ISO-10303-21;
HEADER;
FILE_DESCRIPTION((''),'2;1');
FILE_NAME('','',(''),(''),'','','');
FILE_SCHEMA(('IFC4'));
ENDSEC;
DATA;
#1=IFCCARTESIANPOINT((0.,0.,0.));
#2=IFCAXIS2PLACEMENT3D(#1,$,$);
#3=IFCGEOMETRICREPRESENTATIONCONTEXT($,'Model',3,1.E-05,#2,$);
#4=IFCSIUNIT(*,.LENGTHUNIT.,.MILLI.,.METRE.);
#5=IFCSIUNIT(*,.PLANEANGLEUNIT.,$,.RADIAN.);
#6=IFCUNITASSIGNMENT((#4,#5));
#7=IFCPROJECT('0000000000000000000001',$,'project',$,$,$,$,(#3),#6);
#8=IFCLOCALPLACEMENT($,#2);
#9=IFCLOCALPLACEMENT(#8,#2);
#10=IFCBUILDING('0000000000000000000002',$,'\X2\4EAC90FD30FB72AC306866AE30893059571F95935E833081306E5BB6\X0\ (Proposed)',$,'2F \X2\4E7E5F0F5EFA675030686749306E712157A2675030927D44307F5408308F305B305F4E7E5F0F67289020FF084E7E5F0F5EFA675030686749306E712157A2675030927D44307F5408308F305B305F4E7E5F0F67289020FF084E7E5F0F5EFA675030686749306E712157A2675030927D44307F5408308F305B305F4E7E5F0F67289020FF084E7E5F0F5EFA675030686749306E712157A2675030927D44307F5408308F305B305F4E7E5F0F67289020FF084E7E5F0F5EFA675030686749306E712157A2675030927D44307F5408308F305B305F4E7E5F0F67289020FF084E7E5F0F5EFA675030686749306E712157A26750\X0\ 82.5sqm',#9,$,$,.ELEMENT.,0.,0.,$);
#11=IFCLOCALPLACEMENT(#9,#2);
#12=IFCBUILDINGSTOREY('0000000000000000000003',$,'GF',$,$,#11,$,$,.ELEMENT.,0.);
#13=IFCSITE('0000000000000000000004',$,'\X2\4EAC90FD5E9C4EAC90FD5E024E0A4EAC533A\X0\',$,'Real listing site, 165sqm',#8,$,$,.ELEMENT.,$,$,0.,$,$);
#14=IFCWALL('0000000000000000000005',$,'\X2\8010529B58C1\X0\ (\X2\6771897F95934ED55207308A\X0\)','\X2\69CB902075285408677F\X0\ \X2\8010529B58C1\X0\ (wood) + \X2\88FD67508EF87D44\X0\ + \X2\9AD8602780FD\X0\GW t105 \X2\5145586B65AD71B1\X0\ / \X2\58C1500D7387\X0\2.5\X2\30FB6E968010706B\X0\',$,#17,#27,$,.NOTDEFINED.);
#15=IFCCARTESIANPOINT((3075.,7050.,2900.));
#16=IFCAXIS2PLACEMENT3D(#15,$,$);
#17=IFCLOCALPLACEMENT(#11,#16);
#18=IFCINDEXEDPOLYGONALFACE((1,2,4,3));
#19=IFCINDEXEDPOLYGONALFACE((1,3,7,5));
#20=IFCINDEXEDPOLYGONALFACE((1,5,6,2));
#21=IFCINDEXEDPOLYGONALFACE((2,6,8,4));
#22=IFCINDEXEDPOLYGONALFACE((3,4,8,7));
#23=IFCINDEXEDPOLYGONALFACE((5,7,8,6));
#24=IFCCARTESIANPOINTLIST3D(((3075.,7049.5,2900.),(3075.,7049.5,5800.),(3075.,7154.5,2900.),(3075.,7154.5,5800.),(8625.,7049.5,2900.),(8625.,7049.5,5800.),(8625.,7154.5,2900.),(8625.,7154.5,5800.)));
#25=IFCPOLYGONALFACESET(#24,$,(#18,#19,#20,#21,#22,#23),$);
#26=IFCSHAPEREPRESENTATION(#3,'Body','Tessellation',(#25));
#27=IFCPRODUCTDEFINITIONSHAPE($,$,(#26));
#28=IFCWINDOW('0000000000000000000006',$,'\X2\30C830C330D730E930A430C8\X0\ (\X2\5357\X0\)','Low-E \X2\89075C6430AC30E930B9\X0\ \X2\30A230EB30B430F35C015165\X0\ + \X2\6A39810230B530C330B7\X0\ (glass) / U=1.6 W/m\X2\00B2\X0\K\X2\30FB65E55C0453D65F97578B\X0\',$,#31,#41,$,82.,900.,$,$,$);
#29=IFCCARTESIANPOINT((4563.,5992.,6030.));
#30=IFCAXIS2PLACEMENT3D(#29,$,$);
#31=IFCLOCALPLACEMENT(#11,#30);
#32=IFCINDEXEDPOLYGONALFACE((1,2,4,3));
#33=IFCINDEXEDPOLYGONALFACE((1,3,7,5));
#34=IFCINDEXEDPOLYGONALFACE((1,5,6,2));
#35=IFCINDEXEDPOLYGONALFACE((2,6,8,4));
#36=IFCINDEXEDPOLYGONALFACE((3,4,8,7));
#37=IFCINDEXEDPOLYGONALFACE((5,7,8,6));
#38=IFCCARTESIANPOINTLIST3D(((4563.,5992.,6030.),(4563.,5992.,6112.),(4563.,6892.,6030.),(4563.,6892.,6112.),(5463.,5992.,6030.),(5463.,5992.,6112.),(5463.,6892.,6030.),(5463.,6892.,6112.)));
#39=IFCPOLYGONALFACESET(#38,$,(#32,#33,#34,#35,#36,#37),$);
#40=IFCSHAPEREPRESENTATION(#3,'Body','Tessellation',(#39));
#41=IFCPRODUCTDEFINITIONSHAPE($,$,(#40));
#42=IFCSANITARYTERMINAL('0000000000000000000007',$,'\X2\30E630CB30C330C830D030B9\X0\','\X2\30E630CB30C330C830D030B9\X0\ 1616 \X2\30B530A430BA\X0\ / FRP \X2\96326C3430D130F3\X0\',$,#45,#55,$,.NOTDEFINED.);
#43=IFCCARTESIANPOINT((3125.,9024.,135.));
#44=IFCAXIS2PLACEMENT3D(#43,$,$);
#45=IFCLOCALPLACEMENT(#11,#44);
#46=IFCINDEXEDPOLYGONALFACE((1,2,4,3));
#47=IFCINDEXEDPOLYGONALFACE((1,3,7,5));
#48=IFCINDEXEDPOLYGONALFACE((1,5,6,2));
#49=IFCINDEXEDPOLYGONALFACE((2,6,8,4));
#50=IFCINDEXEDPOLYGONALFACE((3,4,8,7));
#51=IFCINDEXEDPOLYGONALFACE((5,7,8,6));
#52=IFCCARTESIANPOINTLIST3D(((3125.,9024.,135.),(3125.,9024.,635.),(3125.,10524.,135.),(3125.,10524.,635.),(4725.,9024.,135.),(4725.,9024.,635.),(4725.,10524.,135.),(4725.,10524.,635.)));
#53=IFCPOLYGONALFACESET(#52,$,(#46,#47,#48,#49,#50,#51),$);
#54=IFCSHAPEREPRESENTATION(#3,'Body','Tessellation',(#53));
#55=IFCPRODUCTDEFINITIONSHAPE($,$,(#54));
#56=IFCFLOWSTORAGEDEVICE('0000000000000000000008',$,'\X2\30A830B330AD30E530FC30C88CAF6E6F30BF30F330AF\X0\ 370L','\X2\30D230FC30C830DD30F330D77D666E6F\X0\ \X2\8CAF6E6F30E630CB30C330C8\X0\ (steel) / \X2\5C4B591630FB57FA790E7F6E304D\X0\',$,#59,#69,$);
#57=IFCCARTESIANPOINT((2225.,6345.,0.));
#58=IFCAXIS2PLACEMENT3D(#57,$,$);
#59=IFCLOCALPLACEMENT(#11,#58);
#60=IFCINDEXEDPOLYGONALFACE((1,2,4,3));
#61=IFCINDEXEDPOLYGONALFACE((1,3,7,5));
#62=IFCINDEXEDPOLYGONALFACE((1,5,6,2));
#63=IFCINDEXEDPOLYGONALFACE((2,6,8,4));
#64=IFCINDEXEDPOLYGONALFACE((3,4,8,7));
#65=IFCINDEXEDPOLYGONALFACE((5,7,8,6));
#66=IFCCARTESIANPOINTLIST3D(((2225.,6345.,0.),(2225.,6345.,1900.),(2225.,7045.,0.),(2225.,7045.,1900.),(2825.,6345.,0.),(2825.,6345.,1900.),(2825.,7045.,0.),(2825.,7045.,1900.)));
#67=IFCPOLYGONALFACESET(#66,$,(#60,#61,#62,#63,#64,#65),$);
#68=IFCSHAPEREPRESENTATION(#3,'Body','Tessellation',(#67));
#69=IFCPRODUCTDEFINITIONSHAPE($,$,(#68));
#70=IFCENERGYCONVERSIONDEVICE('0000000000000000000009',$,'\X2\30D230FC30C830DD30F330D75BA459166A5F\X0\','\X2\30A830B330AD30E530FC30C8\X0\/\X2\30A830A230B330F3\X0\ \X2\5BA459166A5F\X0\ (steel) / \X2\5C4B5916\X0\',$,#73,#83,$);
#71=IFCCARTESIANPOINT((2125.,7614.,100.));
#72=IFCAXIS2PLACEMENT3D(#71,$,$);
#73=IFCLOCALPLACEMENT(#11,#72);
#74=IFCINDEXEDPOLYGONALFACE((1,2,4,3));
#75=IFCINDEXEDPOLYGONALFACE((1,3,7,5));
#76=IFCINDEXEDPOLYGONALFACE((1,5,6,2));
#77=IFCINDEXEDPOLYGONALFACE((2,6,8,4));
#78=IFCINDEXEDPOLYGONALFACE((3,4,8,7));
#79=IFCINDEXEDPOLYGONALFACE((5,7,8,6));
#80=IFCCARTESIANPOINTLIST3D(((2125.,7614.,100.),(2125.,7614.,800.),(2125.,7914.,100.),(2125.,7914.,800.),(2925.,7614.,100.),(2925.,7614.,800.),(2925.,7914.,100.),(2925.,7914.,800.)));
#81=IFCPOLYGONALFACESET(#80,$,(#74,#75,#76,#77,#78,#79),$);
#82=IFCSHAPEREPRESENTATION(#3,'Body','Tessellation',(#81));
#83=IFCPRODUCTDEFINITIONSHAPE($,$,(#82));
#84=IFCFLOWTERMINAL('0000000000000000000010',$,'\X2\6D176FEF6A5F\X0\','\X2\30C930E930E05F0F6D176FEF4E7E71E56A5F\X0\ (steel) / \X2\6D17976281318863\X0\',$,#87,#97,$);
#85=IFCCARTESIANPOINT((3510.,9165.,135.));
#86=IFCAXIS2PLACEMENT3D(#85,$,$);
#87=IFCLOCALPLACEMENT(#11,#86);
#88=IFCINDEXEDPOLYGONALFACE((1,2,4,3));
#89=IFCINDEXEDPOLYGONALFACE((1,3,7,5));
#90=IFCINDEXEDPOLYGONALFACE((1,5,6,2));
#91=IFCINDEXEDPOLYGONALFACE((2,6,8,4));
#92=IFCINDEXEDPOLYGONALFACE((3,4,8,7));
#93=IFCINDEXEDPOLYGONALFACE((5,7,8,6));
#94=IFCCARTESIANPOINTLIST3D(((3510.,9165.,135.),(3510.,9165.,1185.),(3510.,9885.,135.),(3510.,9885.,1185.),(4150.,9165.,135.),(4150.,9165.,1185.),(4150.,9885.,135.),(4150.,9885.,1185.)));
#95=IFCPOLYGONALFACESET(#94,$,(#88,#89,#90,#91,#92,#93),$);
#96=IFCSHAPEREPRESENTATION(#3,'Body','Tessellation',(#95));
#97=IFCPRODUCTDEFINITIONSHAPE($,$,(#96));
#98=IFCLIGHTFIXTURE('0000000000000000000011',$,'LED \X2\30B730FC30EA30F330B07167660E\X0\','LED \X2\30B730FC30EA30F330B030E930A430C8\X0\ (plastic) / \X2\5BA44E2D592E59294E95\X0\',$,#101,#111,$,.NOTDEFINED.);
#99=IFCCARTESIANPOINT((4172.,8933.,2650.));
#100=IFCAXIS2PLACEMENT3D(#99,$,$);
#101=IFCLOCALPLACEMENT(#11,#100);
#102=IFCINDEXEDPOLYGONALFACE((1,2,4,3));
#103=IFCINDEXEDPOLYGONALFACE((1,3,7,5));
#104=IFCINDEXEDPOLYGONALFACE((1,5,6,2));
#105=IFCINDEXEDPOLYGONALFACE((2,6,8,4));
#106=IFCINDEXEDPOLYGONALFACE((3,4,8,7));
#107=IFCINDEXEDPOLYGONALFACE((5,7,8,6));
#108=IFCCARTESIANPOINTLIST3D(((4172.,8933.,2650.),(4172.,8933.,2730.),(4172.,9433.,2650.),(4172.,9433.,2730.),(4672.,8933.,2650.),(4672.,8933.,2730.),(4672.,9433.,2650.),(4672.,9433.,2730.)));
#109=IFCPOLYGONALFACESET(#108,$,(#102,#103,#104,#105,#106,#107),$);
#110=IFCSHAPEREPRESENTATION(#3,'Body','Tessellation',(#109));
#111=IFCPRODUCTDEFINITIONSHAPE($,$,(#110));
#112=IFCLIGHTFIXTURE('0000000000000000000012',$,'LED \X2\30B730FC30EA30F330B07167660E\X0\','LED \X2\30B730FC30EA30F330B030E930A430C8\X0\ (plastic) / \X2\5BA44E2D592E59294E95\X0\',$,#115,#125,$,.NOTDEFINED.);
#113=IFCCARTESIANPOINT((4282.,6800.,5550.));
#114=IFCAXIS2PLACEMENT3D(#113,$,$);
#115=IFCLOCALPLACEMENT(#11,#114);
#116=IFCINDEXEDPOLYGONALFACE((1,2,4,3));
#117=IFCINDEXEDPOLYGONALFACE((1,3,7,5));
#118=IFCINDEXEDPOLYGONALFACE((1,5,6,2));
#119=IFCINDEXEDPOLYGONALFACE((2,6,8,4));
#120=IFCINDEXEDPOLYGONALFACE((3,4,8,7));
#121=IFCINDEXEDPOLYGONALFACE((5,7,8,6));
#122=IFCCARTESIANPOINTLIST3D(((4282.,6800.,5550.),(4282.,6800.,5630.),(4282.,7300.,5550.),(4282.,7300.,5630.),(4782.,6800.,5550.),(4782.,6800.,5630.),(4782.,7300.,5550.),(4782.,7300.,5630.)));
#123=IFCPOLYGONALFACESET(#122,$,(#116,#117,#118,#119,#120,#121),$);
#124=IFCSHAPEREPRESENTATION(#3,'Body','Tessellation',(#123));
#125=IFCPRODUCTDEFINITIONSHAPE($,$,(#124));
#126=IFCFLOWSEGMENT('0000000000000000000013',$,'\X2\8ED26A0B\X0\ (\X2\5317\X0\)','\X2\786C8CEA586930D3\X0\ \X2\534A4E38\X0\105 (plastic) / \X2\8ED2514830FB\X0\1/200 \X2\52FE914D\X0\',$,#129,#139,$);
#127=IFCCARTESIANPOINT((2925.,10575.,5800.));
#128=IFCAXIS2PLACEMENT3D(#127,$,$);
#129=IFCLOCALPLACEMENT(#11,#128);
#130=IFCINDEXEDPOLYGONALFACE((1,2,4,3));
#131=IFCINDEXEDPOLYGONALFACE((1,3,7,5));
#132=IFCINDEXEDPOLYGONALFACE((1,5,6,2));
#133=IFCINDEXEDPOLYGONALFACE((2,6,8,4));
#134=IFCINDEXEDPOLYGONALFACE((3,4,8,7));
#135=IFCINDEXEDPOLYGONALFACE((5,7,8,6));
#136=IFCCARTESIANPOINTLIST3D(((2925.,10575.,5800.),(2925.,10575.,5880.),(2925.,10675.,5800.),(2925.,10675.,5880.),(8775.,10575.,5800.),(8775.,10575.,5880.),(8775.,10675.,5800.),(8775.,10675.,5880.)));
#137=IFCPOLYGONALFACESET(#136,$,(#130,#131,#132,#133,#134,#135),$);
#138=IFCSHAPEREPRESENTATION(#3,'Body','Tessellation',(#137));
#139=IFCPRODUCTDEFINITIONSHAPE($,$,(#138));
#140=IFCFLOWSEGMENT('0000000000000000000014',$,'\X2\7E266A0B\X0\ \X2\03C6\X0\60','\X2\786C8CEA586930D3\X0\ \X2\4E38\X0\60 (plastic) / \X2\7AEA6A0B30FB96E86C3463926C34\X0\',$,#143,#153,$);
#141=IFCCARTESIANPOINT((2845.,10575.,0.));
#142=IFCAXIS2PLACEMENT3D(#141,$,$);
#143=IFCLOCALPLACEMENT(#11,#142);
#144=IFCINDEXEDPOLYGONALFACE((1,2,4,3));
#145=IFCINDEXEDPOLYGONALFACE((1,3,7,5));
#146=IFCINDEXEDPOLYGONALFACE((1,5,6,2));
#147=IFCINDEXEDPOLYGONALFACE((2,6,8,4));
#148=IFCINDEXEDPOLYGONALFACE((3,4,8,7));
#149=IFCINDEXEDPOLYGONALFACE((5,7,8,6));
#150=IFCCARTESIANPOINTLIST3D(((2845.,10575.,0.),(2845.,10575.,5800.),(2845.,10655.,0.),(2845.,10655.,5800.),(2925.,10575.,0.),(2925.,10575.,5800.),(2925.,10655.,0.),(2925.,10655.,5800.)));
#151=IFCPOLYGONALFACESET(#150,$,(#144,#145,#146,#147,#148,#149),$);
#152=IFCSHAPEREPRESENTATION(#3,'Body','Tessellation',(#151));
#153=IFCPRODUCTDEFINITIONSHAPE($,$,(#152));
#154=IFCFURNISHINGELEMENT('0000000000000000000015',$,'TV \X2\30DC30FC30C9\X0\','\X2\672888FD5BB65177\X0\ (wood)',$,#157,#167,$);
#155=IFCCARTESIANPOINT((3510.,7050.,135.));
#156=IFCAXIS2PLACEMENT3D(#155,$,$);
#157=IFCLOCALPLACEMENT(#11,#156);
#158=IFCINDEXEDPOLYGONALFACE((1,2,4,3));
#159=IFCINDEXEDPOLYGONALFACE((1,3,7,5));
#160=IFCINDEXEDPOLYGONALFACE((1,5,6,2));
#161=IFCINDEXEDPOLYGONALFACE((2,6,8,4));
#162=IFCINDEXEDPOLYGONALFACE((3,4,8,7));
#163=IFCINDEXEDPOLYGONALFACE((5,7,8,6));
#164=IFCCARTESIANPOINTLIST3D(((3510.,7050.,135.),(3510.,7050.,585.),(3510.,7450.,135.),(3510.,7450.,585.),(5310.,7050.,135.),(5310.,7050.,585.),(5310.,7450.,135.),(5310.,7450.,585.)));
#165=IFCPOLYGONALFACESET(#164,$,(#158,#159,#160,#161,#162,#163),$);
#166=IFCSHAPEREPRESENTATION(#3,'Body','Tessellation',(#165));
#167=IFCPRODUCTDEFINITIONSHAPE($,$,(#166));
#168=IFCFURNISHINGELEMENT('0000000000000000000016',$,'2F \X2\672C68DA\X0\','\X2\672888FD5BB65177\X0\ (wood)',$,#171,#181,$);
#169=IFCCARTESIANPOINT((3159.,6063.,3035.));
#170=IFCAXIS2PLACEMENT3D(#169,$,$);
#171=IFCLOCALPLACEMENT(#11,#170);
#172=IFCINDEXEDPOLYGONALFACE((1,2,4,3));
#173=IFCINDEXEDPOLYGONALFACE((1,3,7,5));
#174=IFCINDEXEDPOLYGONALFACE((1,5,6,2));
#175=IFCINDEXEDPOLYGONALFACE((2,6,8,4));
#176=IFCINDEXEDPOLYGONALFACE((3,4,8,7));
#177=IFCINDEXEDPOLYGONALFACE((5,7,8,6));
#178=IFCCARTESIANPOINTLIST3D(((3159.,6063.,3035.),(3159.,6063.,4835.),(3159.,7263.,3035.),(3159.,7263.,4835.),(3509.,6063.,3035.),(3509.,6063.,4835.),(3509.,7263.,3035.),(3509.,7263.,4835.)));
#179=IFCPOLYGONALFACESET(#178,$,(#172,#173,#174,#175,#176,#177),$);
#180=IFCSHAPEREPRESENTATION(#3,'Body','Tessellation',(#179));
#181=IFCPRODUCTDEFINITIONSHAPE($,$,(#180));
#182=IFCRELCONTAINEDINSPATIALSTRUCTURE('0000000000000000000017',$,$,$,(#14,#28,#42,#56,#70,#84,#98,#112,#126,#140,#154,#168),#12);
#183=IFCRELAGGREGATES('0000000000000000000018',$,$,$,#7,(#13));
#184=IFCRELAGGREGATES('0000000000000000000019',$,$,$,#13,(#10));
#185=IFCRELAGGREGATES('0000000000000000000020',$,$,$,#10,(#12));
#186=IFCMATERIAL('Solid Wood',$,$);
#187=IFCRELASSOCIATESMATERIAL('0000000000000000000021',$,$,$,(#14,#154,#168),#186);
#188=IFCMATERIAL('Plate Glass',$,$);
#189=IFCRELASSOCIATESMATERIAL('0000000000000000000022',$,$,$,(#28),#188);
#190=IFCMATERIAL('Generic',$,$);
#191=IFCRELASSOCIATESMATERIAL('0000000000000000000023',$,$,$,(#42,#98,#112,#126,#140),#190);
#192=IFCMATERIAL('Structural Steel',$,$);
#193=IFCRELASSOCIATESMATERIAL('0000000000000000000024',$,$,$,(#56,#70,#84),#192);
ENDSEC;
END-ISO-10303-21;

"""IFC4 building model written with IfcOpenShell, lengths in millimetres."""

from ifc_helpers import new_model, si_unit, frame, frame_2d, origin, place, context, project, spatial, rectangle, extrude, material, element, save


model = new_model("IFC4")

# Units and contexts
model_context = context("Model", 3, precision=1e-05, world=origin())
ifc_project = project(units=[si_unit("LENGTHUNIT", "METRE", prefix="MILLI"), si_unit("PLANEANGLEUNIT", "RADIAN")], contexts=[model_context])

# Site, building, storey
site_placement = place(None, origin())
site = spatial("IfcSite", under=ifc_project, at=site_placement, Name="京都府京都市上京区", ObjectType="Real listing site, 165sqm", CompositionType="ELEMENT", RefElevation=0.0)
building_placement = place(site_placement, origin())
building = spatial("IfcBuilding", under=site, at=building_placement, Name="京都・犬と暮らす土間広めの家 (Proposed)", ObjectType="2F 乾式建材と杉の無垢材を組み合わせた乾式木造（乾式建材と杉の無垢材を組み合わせた乾式木造（乾式建材と杉の無垢材を組み合わせた乾式木造（乾式建材と杉の無垢材を組み合わせた乾式木造（乾式建材と杉の無垢材を組み合わせた乾式木造（乾式建材と杉の無垢材 82.5sqm", CompositionType="ELEMENT", ElevationOfRefHeight=0.0, ElevationOfTerrain=0.0)
storey_placement = place(building_placement, origin())
storey = spatial("IfcBuildingStorey", under=building, at=storey_placement, Name="GF", CompositionType="ELEMENT", Elevation=0.0)

# Shared definitions
ifc_material_1 = material(Name="Solid Wood")

# Shared definitions
ifc_material_2 = material(Name="Plate Glass")

# Wall
wall_1_placement = place(storey_placement, frame((3075.0, 7050.0, 2900.0)))
element("IfcWall", 1, at=wall_1_placement, inside=storey, material=ifc_material_1, Name="耐力壁 (東西間仕切り)", Description="構造用合板 耐力壁 (wood) + 製材軸組 + 高性能GW t105 充填断熱 / 壁倍率2.5・準耐火", PredefinedType="NOTDEFINED", context=model_context, shape_type="SweptSolid", body=[
    extrude(rectangle(XDim=5550.0, YDim=105.0, at=frame_2d((2775.0, 52.0))), frame((3075.0, 7050.0, 2900.0)), (0.0, 0.0, 1.0), 2900.0),
])

# Window
window_1_placement = place(storey_placement, frame((4563.0, 5992.0, 6030.0)))
element("IfcWindow", 2, at=window_1_placement, inside=storey, material=ifc_material_2, Name="トップライト (南)", Description="Low-E 複層ガラス アルゴン封入 + 樹脂サッシ (glass) / U=1.6 W/m²K・日射取得型", OverallHeight=82.0, OverallWidth=900.0, context=model_context, shape_type="SweptSolid", body=[
    extrude(rectangle(XDim=900.0, YDim=900.0, at=frame_2d((450.0, 450.0))), frame((4563.0, 5992.0, 6030.0)), (0.0, 0.0, 1.0), 82.0),
])

# Sanitary terminal
ifc_material_3 = material(Name="Generic")
sanitary_terminal_placement = place(storey_placement, frame((3125.0, 9024.0, 135.0)))
element("IfcSanitaryTerminal", 3, at=sanitary_terminal_placement, inside=storey, material=ifc_material_3, Name="ユニットバス", Description="ユニットバス 1616 サイズ / FRP 防水パン", PredefinedType="NOTDEFINED", context=model_context, shape_type="SweptSolid", body=[
    extrude(rectangle(XDim=1600.0, YDim=1500.0, at=frame_2d((800.0, 750.0))), frame((3125.0, 9024.0, 135.0)), (0.0, 0.0, 1.0), 500.0),
])

# Flow storage device
ifc_material_4 = material(Name="Structural Steel")
flow_storage_device_placement = place(storey_placement, frame((2225.0, 6345.0, 0.0)))
element("IfcFlowStorageDevice", 4, at=flow_storage_device_placement, inside=storey, material=ifc_material_4, Name="エコキュート貯湯タンク 370L", Description="ヒートポンプ給湯 貯湯ユニット (steel) / 屋外・基礎置き", context=model_context, shape_type="SweptSolid", body=[
    extrude(rectangle(XDim=600.0, YDim=700.0, at=frame_2d((300.0, 350.0))), frame((2225.0, 6345.0, 0.0)), (0.0, 0.0, 1.0), 1900.0),
])

# Energy conversion device
energy_conversion_device_placement = place(storey_placement, frame((2125.0, 7614.0, 100.0)))
element("IfcEnergyConversionDevice", 5, at=energy_conversion_device_placement, inside=storey, material=ifc_material_4, Name="ヒートポンプ室外機", Description="エコキュート/エアコン 室外機 (steel) / 屋外", context=model_context, shape_type="SweptSolid", body=[
    extrude(rectangle(XDim=800.0, YDim=300.0, at=frame_2d((400.0, 150.0))), frame((2125.0, 7614.0, 100.0)), (0.0, 0.0, 1.0), 700.0),
])

# Flow terminal
flow_terminal_placement = place(storey_placement, frame((3510.0, 9165.0, 135.0)))
element("IfcFlowTerminal", 6, at=flow_terminal_placement, inside=storey, material=ifc_material_4, Name="洗濯機", Description="ドラム式洗濯乾燥機 (steel) / 洗面脱衣", context=model_context, shape_type="SweptSolid", body=[
    extrude(rectangle(XDim=640.0, YDim=720.0, at=frame_2d((320.0, 360.0))), frame((3510.0, 9165.0, 135.0)), (0.0, 0.0, 1.0), 1050.0),
])

# Light fixtures
light_fixture_1_placement = place(storey_placement, frame((4172.0, 8933.0, 2650.0)))
element("IfcLightFixture", 7, at=light_fixture_1_placement, inside=storey, material=ifc_material_3, Name="LED シーリング照明", Description="LED シーリングライト (plastic) / 室中央天井", PredefinedType="NOTDEFINED", context=model_context, shape_type="SweptSolid", body=[
    extrude(rectangle(XDim=500.0, YDim=500.0, at=frame_2d((250.0, 250.0))), frame((4172.0, 8933.0, 2650.0)), (0.0, 0.0, 1.0), 80.0),
])
light_fixture_2_placement = place(storey_placement, frame((4282.0, 6800.0, 5550.0)))
element("IfcLightFixture", 8, at=light_fixture_2_placement, inside=storey, material=ifc_material_3, Name="LED シーリング照明", Description="LED シーリングライト (plastic) / 室中央天井", PredefinedType="NOTDEFINED", context=model_context, shape_type="SweptSolid", body=[
    extrude(rectangle(XDim=500.0, YDim=500.0, at=frame_2d((250.0, 250.0))), frame((4282.0, 6800.0, 5550.0)), (0.0, 0.0, 1.0), 80.0),
])

# Flow segments
flow_segment_1_placement = place(storey_placement, frame((2925.0, 10575.0, 5800.0)))
element("IfcFlowSegment", 9, at=flow_segment_1_placement, inside=storey, material=ifc_material_3, Name="軒樋 (北)", Description="硬質塩ビ 半丸105 (plastic) / 軒先・1/200 勾配", context=model_context, shape_type="SweptSolid", body=[
    extrude(rectangle(XDim=5850.0, YDim=100.0, at=frame_2d((2925.0, 50.0))), frame((2925.0, 10575.0, 5800.0)), (0.0, 0.0, 1.0), 80.0),
])
flow_segment_2_placement = place(storey_placement, frame((2845.0, 10575.0, 0.0)))
element("IfcFlowSegment", 10, at=flow_segment_2_placement, inside=storey, material=ifc_material_3, Name="縦樋 φ60", Description="硬質塩ビ 丸60 (plastic) / 竪樋・雨水排水", context=model_context, shape_type="SweptSolid", body=[
    extrude(rectangle(XDim=80.0, YDim=80.0, at=frame_2d((40.0, 40.0))), frame((2845.0, 10575.0, 0.0)), (0.0, 0.0, 1.0), 5800.0),
])

# Furnishing elements
furnishing_1_placement = place(storey_placement, frame((3510.0, 7050.0, 135.0)))
element("IfcFurnishingElement", 11, at=furnishing_1_placement, inside=storey, material=ifc_material_1, Name="TV ボード", Description="木製家具 (wood)", context=model_context, shape_type="SweptSolid", body=[
    extrude(rectangle(XDim=1800.0, YDim=400.0, at=frame_2d((900.0, 200.0))), frame((3510.0, 7050.0, 135.0)), (0.0, 0.0, 1.0), 450.0),
])
furnishing_2_placement = place(storey_placement, frame((3159.0, 6063.0, 3035.0)))
element("IfcFurnishingElement", 12, at=furnishing_2_placement, inside=storey, material=ifc_material_1, Name="2F 本棚", Description="木製家具 (wood)", context=model_context, shape_type="SweptSolid", body=[
    extrude(rectangle(XDim=350.0, YDim=1200.0, at=frame_2d((175.0, 600.0))), frame((3159.0, 6063.0, 3035.0)), (0.0, 0.0, 1.0), 1800.0),
])

save(model, "model.ifc")
